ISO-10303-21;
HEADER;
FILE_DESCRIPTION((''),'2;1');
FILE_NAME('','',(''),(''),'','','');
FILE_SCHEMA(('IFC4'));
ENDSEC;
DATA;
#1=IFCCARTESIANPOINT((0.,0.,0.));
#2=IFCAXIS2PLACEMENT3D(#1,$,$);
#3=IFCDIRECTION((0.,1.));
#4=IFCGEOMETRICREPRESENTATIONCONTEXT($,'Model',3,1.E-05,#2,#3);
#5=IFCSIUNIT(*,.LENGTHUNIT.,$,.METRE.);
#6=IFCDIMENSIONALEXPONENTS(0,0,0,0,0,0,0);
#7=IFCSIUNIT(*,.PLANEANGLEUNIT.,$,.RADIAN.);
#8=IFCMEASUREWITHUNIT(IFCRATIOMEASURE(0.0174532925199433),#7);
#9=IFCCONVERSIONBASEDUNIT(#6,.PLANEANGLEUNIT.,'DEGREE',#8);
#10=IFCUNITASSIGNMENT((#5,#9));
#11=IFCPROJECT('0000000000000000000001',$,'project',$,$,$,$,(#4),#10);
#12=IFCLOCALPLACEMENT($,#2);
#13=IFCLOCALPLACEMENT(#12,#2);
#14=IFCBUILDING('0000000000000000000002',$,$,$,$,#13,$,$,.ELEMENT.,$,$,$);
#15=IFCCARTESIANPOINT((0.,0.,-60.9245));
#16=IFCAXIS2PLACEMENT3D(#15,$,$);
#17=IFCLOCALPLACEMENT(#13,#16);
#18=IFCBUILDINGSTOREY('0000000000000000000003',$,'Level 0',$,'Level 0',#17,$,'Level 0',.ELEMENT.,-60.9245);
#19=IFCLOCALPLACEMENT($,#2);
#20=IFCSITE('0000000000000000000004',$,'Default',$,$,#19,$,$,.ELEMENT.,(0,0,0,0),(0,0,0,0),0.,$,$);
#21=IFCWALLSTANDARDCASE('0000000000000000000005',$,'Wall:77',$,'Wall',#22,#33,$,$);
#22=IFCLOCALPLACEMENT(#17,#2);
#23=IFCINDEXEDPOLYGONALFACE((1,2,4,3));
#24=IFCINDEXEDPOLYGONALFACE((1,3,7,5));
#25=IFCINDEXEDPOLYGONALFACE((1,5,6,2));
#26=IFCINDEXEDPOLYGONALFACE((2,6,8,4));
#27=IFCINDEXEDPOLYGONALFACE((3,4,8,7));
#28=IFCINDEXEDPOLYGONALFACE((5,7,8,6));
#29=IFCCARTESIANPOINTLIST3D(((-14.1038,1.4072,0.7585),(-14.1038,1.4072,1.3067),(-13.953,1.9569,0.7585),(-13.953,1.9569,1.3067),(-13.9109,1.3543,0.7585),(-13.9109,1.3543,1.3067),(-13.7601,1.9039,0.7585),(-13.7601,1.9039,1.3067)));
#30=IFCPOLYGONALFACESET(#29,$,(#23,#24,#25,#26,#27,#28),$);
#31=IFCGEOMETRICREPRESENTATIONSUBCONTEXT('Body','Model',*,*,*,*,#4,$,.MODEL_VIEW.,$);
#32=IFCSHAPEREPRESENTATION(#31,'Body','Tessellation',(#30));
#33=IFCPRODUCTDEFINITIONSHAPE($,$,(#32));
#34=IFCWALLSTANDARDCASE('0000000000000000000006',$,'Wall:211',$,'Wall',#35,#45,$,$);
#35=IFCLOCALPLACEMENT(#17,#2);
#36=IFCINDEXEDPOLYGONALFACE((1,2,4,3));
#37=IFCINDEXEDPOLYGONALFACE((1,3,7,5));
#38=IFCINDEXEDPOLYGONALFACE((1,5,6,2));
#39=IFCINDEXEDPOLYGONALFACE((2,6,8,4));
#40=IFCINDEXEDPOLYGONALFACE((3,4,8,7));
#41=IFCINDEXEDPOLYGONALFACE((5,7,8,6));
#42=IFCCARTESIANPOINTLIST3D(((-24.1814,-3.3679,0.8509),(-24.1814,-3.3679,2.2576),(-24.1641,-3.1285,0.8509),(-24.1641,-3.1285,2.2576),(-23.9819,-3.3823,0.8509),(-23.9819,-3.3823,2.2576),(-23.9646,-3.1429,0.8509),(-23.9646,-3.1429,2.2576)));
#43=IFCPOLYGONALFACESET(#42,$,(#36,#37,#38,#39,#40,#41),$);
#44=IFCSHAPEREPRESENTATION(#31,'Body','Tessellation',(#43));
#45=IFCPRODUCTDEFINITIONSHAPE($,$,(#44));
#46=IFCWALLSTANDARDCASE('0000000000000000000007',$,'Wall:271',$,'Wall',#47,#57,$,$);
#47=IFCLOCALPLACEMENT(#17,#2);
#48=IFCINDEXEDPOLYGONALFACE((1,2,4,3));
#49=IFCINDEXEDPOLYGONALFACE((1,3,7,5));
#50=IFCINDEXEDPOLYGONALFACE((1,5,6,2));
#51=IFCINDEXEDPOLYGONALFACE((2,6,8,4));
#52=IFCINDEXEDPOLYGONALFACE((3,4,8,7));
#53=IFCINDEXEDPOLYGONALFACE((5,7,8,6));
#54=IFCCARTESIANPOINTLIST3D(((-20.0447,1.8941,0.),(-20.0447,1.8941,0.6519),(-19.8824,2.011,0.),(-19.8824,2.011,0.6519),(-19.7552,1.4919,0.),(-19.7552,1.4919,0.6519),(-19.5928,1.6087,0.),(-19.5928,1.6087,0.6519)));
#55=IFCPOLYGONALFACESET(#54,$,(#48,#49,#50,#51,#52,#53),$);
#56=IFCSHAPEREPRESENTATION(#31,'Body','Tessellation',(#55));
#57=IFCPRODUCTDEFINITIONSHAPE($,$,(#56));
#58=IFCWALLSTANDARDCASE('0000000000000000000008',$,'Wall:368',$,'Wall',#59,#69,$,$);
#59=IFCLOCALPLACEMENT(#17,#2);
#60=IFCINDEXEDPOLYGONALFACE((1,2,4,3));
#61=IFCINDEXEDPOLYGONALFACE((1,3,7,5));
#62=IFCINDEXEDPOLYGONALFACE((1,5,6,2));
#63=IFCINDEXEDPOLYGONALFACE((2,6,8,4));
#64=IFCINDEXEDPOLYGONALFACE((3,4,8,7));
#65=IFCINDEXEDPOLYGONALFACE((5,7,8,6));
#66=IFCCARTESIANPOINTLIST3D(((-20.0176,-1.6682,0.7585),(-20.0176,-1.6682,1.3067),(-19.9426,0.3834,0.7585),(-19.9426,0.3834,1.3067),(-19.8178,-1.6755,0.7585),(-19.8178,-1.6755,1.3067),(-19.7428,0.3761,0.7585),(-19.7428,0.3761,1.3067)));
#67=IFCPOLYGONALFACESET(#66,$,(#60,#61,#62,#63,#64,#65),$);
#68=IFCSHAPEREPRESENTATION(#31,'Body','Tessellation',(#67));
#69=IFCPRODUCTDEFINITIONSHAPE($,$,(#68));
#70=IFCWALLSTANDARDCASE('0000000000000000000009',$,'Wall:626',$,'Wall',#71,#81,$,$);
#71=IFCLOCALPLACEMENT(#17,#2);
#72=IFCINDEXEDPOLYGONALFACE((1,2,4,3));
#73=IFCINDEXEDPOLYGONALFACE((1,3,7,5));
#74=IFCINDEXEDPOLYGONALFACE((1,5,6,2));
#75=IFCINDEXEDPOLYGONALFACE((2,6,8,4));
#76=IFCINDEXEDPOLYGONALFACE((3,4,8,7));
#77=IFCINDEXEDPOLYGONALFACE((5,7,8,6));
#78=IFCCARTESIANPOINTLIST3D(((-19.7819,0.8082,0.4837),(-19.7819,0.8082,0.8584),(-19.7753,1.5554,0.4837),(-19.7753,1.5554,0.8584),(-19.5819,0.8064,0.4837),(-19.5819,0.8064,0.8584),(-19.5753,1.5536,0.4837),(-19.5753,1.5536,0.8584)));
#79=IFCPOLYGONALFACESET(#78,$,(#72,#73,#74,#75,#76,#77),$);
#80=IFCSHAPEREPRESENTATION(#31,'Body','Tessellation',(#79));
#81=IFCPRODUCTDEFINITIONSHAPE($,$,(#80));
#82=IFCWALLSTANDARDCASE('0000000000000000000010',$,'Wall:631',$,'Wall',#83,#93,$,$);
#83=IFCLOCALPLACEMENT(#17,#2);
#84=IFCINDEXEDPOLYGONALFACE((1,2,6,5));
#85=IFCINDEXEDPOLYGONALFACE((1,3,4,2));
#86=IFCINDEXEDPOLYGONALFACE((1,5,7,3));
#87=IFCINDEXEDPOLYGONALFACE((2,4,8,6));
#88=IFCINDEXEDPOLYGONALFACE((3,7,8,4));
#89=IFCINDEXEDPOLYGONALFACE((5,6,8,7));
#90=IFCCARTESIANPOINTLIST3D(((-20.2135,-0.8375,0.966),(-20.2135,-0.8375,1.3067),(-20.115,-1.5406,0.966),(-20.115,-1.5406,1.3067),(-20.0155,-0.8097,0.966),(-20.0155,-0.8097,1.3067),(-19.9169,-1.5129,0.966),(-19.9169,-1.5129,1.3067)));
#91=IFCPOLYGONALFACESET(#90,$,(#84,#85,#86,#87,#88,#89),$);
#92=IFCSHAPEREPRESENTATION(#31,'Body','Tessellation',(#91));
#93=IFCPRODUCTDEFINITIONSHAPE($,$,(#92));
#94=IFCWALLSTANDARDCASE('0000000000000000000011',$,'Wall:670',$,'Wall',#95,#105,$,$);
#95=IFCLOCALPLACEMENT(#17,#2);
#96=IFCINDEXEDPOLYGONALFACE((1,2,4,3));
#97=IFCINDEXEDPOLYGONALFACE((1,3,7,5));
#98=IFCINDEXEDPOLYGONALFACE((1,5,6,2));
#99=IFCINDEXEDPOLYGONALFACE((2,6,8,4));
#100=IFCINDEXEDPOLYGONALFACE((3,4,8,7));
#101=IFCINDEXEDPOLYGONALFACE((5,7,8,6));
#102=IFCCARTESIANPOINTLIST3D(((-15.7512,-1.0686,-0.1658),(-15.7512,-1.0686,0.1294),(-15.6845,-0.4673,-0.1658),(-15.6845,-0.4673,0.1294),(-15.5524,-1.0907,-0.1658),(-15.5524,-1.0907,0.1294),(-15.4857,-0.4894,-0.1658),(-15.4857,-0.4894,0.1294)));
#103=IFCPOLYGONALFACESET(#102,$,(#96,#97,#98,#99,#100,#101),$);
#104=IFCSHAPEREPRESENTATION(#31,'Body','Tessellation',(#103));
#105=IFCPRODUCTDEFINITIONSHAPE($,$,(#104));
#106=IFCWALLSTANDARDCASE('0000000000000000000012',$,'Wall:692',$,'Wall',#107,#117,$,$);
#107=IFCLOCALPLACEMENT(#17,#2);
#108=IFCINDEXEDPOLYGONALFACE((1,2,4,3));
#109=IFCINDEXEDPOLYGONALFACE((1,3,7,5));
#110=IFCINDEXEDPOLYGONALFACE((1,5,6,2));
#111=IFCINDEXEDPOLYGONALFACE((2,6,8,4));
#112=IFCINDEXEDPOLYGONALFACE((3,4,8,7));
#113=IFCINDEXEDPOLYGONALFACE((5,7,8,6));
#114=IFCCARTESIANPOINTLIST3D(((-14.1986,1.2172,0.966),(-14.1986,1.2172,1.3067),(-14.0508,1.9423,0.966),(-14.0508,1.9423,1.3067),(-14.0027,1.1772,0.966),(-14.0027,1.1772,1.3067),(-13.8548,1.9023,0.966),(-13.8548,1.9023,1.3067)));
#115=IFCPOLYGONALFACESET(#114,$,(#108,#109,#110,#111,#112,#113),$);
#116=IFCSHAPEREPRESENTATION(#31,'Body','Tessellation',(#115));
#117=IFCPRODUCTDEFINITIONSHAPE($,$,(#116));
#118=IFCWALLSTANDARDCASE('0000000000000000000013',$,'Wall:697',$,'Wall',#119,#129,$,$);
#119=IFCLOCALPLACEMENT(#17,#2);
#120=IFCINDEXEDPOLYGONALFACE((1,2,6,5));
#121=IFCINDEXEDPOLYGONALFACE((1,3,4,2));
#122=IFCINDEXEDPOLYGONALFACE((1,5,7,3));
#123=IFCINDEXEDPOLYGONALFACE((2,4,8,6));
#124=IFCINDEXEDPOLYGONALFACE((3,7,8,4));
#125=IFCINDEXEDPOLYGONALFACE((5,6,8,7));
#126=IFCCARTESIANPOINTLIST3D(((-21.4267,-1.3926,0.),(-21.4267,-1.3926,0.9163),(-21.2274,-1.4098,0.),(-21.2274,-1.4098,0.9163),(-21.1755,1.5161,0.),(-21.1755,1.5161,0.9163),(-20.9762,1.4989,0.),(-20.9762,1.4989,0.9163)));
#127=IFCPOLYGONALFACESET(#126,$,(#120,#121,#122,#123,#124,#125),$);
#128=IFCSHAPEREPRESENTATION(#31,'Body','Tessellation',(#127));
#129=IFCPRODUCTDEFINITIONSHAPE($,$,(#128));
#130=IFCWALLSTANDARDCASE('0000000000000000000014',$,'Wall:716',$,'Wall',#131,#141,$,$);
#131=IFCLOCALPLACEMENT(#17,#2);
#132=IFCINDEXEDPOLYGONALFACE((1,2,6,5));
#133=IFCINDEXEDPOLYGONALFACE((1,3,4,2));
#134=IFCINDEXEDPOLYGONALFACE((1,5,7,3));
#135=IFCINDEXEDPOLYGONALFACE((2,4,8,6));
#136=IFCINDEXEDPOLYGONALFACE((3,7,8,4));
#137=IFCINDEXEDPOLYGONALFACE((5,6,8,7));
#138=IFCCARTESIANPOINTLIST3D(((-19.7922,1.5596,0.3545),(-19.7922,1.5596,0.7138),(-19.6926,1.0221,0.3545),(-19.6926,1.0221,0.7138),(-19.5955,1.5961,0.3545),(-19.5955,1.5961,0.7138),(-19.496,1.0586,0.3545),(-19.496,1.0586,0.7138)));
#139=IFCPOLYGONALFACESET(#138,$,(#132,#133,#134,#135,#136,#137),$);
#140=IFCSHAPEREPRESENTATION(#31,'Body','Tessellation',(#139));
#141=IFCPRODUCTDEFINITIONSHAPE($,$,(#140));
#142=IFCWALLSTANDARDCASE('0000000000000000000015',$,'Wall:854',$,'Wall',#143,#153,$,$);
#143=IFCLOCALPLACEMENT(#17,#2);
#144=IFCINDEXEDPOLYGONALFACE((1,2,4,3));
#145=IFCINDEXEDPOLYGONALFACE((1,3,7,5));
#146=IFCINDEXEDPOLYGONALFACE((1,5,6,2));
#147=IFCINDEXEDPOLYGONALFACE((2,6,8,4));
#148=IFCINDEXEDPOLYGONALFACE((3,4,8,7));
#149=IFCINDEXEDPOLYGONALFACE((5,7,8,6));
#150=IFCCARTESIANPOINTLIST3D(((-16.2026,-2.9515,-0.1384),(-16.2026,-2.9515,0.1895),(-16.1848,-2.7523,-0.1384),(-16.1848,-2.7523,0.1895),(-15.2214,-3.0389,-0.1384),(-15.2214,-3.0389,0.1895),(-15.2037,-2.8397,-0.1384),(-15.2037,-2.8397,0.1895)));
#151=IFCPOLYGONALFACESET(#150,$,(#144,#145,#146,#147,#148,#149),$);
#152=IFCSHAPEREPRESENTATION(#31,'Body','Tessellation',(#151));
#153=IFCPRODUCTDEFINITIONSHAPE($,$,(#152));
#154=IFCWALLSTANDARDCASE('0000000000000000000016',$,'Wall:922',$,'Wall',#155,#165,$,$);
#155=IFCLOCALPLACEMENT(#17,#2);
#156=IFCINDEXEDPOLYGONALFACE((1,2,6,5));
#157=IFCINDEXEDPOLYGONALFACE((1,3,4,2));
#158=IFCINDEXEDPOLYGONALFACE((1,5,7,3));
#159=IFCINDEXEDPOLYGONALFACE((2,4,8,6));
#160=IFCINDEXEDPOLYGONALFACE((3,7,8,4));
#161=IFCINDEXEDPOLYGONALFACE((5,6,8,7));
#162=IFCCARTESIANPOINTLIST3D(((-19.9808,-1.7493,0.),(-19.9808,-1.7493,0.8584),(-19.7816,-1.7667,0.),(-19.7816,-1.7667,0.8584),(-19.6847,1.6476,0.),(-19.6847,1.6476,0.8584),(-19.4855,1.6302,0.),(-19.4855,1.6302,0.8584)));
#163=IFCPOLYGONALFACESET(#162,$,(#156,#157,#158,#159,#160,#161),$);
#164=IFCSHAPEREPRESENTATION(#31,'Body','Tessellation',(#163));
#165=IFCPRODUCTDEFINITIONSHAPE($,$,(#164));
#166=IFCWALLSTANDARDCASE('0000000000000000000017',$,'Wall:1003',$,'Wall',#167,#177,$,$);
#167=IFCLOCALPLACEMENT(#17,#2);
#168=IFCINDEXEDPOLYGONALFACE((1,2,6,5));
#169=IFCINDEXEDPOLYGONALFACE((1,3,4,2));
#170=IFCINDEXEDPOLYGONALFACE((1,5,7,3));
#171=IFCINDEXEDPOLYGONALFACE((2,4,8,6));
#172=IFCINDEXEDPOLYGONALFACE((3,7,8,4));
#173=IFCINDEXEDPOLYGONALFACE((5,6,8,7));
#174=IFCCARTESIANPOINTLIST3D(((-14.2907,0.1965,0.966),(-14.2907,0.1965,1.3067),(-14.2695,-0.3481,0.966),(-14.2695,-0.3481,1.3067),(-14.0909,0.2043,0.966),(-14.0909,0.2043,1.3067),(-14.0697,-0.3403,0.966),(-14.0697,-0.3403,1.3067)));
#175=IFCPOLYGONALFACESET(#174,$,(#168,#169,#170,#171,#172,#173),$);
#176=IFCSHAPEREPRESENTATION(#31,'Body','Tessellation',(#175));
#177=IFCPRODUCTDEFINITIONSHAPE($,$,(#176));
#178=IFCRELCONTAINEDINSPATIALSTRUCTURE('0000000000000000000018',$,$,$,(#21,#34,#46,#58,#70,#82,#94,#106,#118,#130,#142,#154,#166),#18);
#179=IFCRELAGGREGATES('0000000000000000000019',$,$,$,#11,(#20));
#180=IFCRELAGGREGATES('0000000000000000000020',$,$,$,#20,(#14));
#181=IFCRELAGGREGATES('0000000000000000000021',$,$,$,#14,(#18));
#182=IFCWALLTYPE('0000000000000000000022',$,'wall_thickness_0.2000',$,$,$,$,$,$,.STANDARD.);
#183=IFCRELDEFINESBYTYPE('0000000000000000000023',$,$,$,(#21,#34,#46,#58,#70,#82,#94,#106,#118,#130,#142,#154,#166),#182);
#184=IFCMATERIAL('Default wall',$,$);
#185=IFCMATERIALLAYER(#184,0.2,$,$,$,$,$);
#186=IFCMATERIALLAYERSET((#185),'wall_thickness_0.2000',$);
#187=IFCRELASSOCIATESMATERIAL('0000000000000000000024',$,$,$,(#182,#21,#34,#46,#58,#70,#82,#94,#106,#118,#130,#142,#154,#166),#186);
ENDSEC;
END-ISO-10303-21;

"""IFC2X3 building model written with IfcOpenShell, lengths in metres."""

from ifc_helpers import new_model, entity, si_unit, converted_unit, direction, frame, origin, place, context, subcontext, project, spatial, polyline, outline, extrude, material, layer, layer_set, layer_usage, type_object, element, save


model = new_model("IFC2X3")

# Units and contexts
model_context = context("Model", 3, precision=1e-05, world=origin(), true_north=direction((0.0, 1.0)))
body_context = subcontext(model_context, "Body", "Model", "MODEL_VIEW")
ifc_project = project(units=[si_unit("LENGTHUNIT", "METRE"), converted_unit("PLANEANGLEUNIT", "DEGREE", entity("IfcRatioMeasure", 0.0174532925199433), si_unit("PLANEANGLEUNIT", "RADIAN"), dimensions=[0, 0, 0, 0, 0, 0, 0])], contexts=[model_context])

# Site, building, storey
site_placement = place(None, origin())
site = spatial("IfcSite", under=ifc_project, at=site_placement, Name="Default", CompositionType="ELEMENT", RefLatitude=(0, 0, 0, 0), RefLongitude=(0, 0, 0, 0), RefElevation=0.0)
placement_1 = place(None, origin())
building_placement = place(placement_1, origin())
building = spatial("IfcBuilding", under=site, at=building_placement, CompositionType="ELEMENT")
storey_placement = place(building_placement, frame((0.0, 0.0, -60.9245)))
storey = spatial("IfcBuildingStorey", under=building, at=storey_placement, Name="Level 0", ObjectType="Level 0", LongName="Level 0", CompositionType="ELEMENT", Elevation=-60.9245)

# Walls
ifc_material = material(Name="Default wall")
ifc_layer = layer(ifc_material, 0.2)
ifc_layer_set = layer_set([ifc_layer], Name="wall_thickness_0.2000")
ifc_layer_usage = layer_usage(ifc_layer_set, "AXIS2", "POSITIVE", -0.1)
wall_type = type_object("IfcWallType", Name="wall_thickness_0.2000", PredefinedType="STANDARD", material=ifc_layer_set)
placement_2 = place(building_placement, frame((0.0, 0.0, -60.166)))
wall_1_placement = place(placement_2, frame((-14.0074, 1.3807, 0.0), z_axis=(0.0, 0.0, 1.0), x_axis=(0.264589, 0.964361, 0.0)))
element("IfcWallStandardCase", 1, at=wall_1_placement, inside=storey, type_object=wall_type, material=ifc_layer_usage, Name="Wall:77", ObjectType="Wall", context=body_context, shape_type="SweptSolid", body=[
    extrude(outline(polyline([(0.57, -0.1), (0.57, 0.1), (0.0, 0.1), (0.0, -0.1), (0.57, -0.1)])), origin(), (0.0, 0.0, 1.0), 0.5482),
])
placement_3 = place(building_placement, frame((0.0, 0.0, -60.0736)))
wall_2_placement = place(placement_3, frame((-24.0643, -3.1357, 0.0), z_axis=(0.0, 0.0, 1.0), x_axis=(-0.072058, -0.9974, 0.0)))
element("IfcWallStandardCase", 2, at=wall_2_placement, inside=storey, type_object=wall_type, material=ifc_layer_usage, Name="Wall:211", ObjectType="Wall", context=body_context, shape_type="SweptSolid", body=[
    extrude(outline(polyline([(0.24, -0.1), (0.24, 0.1), (0.0, 0.1), (0.0, -0.1), (0.24, -0.1)])), origin(), (0.0, 0.0, 1.0), 1.4068),
])
wall_3_placement = place(storey_placement, frame((-19.674, 1.5503, 0.0), z_axis=(0.0, 0.0, 1.0), x_axis=(-0.584248, 0.811575, 0.0)))
element("IfcWallStandardCase", 3, at=wall_3_placement, inside=storey, type_object=wall_type, material=ifc_layer_usage, Name="Wall:271", ObjectType="Wall", context=body_context, shape_type="SweptSolid", body=[
    extrude(outline(polyline([(0.4956, -0.1), (0.4956, 0.1), (0.0, 0.1), (0.0, -0.1), (0.4956, -0.1)])), origin(), (0.0, 0.0, 1.0), 0.6519),
])
placement_4 = place(building_placement, frame((0.0, 0.0, -60.166)))
wall_4_placement = place(placement_4, frame((-19.8427, 0.3797, 0.0), z_axis=(0.0, 0.0, 1.0), x_axis=(-0.03653, -0.999333, 0.0)))
element("IfcWallStandardCase", 4, at=wall_4_placement, inside=storey, type_object=wall_type, material=ifc_layer_usage, Name="Wall:368", ObjectType="Wall", context=body_context, shape_type="SweptSolid", body=[
    extrude(outline(polyline([(2.0529, -0.1), (2.0529, 0.1), (0.0, 0.1), (0.0, -0.1), (2.0529, -0.1)])), origin(), (0.0, 0.0, 1.0), 0.5482),
])
placement_5 = place(building_placement, frame((0.0, 0.0, -60.4408)))
wall_5_placement = place(placement_5, frame((-19.6753, 1.5545, 0.0), z_axis=(0.0, 0.0, 1.0), x_axis=(-0.008847, -0.999961, 0.0)))
element("IfcWallStandardCase", 5, at=wall_5_placement, inside=storey, type_object=wall_type, material=ifc_layer_usage, Name="Wall:626", ObjectType="Wall", context=body_context, shape_type="SweptSolid", body=[
    extrude(outline(polyline([(0.7472, -0.1), (0.7472, 0.1), (0.0, 0.1), (0.0, -0.1), (0.7472, -0.1)])), origin(), (0.0, 0.0, 1.0), 0.3746),
])
placement_6 = place(building_placement, frame((0.0, 0.0, -59.9585)))
wall_6_placement = place(placement_6, frame((-20.1145, -0.8236, 0.0), z_axis=(0.0, 0.0, 1.0), x_axis=(0.138799, -0.990321, 0.0)))
element("IfcWallStandardCase", 6, at=wall_6_placement, inside=storey, type_object=wall_type, material=ifc_layer_usage, Name="Wall:631", ObjectType="Wall", context=body_context, shape_type="SweptSolid", body=[
    extrude(outline(polyline([(0.71, -0.1), (0.71, 0.1), (0.0, 0.1), (0.0, -0.1), (0.71, -0.1)])), origin(), (0.0, 0.0, 1.0), 0.3407),
])
placement_7 = place(building_placement, frame((0.0, 0.0, -61.0903)))
wall_7_placement = place(placement_7, frame((-15.5851, -0.4784, 0.0), z_axis=(0.0, 0.0, 1.0), x_axis=(-0.110246, -0.993904, 0.0)))
element("IfcWallStandardCase", 7, at=wall_7_placement, inside=storey, type_object=wall_type, material=ifc_layer_usage, Name="Wall:670", ObjectType="Wall", context=body_context, shape_type="SweptSolid", body=[
    extrude(outline(polyline([(0.605, -0.1), (0.605, 0.1), (0.0, 0.1), (0.0, -0.1), (0.605, -0.1)])), origin(), (0.0, 0.0, 1.0), 0.2952),
])
placement_8 = place(building_placement, frame((0.0, 0.0, -59.9585)))
wall_8_placement = place(placement_8, frame((-14.1006, 1.1972, 0.0), z_axis=(0.0, 0.0, 1.0), x_axis=(0.199813, 0.979834, 0.0)))
element("IfcWallStandardCase", 8, at=wall_8_placement, inside=storey, type_object=wall_type, material=ifc_layer_usage, Name="Wall:692", ObjectType="Wall", context=body_context, shape_type="SweptSolid", body=[
    extrude(outline(polyline([(0.74, -0.1), (0.74, 0.1), (0.0, 0.1), (0.0, -0.1), (0.74, -0.1)])), origin(), (0.0, 0.0, 1.0), 0.3407),
])
wall_9_placement = place(storey_placement, frame((-21.327, -1.4012, 0.0), z_axis=(0.0, 0.0, 1.0), x_axis=(0.086043, 0.996291, 0.0)))
element("IfcWallStandardCase", 9, at=wall_9_placement, inside=storey, type_object=wall_type, material=ifc_layer_usage, Name="Wall:697", ObjectType="Wall", context=body_context, shape_type="SweptSolid", body=[
    extrude(outline(polyline([(2.9196, -0.1), (2.9196, 0.1), (0.0, 0.1), (0.0, -0.1), (2.9196, -0.1)])), origin(), (0.0, 0.0, 1.0), 0.9163),
])
placement_9 = place(building_placement, frame((0.0, 0.0, -60.57)))
wall_10_placement = place(placement_9, frame((-19.6938, 1.5779, 0.0), z_axis=(0.0, 0.0, 1.0), x_axis=(0.18211, -0.983278, 0.0)))
element("IfcWallStandardCase", 10, at=wall_10_placement, inside=storey, type_object=wall_type, material=ifc_layer_usage, Name="Wall:716", ObjectType="Wall", context=body_context, shape_type="SweptSolid", body=[
    extrude(outline(polyline([(0.5466, -0.1), (0.5466, 0.1), (0.0, 0.1), (0.0, -0.1), (0.5466, -0.1)])), origin(), (0.0, 0.0, 1.0), 0.3593),
])
placement_10 = place(building_placement, frame((0.0, 0.0, -61.0629)))
wall_11_placement = place(placement_10, frame((-16.1937, -2.8519, 0.0), z_axis=(0.0, 0.0, 1.0), x_axis=(0.996059, -0.088692, 0.0)))
element("IfcWallStandardCase", 11, at=wall_11_placement, inside=storey, type_object=wall_type, material=ifc_layer_usage, Name="Wall:854", ObjectType="Wall", context=body_context, shape_type="SweptSolid", body=[
    extrude(outline(polyline([(0.985, -0.1), (0.985, 0.1), (0.0, 0.1), (0.0, -0.1), (0.985, -0.1)])), origin(), (0.0, 0.0, 1.0), 0.3279),
])
wall_12_placement = place(storey_placement, frame((-19.8812, -1.758, 0.0), z_axis=(0.0, 0.0, 1.0), x_axis=(0.086839, 0.996222, 0.0)))
element("IfcWallStandardCase", 12, at=wall_12_placement, inside=storey, type_object=wall_type, material=ifc_layer_usage, Name="Wall:922", ObjectType="Wall", context=body_context, shape_type="SweptSolid", body=[
    extrude(outline(polyline([(3.4097, -0.1), (3.4097, 0.1), (0.0, 0.1), (0.0, -0.1), (3.4097, -0.1)])), origin(), (0.0, 0.0, 1.0), 0.8584),
])
placement_11 = place(building_placement, frame((0.0, 0.0, -59.9585)))
wall_13_placement = place(placement_11, frame((-14.1908, 0.2004, 0.0), z_axis=(0.0, 0.0, 1.0), x_axis=(0.038878, -0.999244, 0.0)))
element("IfcWallStandardCase", 13, at=wall_13_placement, inside=storey, type_object=wall_type, material=ifc_layer_usage, Name="Wall:1003", ObjectType="Wall", context=body_context, shape_type="SweptSolid", body=[
    extrude(outline(polyline([(0.545, -0.1), (0.545, 0.1), (0.0, 0.1), (0.0, -0.1), (0.545, -0.1)])), origin(), (0.0, 0.0, 1.0), 0.3407),
])

save(model, "model.ifc")
